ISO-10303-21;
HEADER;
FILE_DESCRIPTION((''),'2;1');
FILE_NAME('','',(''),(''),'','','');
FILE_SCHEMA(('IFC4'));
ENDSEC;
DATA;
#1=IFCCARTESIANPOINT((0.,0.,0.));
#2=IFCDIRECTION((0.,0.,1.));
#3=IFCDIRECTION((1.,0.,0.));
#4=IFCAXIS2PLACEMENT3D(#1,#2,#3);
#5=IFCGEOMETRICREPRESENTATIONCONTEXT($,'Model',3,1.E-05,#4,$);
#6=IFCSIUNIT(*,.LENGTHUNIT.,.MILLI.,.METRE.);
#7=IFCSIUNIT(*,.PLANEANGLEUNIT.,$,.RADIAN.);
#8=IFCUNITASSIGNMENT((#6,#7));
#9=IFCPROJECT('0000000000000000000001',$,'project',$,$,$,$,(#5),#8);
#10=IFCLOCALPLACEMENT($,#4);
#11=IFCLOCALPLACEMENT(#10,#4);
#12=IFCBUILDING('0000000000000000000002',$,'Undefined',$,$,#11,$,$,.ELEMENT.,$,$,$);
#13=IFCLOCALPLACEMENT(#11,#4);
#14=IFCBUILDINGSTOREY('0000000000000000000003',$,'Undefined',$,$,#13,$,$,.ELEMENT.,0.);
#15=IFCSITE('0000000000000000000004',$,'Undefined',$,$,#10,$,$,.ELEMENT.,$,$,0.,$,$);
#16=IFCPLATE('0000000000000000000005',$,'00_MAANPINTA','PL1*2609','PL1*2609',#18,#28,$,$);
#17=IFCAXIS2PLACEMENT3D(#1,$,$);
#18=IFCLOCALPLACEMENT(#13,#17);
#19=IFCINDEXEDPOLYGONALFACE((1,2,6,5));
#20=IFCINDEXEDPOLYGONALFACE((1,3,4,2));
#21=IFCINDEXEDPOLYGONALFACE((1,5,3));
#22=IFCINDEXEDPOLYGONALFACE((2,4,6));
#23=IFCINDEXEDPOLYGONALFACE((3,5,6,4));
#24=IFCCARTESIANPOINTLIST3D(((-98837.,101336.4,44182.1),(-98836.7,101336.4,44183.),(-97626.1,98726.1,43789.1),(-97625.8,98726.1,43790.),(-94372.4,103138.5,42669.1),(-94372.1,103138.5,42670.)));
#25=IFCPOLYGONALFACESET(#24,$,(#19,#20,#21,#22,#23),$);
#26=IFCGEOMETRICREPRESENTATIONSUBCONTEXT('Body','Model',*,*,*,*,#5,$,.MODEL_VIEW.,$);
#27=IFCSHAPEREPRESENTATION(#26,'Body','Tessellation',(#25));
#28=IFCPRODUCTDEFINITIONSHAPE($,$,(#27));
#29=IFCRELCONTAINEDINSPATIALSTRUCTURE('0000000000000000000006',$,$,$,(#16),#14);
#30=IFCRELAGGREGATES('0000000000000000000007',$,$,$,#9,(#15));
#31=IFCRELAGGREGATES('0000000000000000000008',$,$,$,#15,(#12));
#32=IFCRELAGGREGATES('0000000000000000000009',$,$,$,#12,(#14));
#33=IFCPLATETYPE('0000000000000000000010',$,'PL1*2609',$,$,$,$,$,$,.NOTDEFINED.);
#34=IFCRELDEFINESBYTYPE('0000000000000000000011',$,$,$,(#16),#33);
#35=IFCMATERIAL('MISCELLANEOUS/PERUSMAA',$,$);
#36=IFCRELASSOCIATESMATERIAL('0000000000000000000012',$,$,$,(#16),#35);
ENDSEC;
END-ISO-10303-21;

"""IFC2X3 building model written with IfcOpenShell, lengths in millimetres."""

from ifc_helpers import new_model, si_unit, frame, origin_with_axes, place, context, subcontext, project, spatial, polyline, outline, extrude, material, type_object, element, save


model = new_model("IFC2X3")

# Units and contexts
model_context = context("Model", 3, precision=1e-05, world=origin_with_axes())
body_context = subcontext(model_context, "Body", "Model", "MODEL_VIEW")
ifc_project = project(units=[si_unit("LENGTHUNIT", "METRE", prefix="MILLI"), si_unit("PLANEANGLEUNIT", "RADIAN")], contexts=[model_context])

# Site, building, storey
site_placement = place(None, origin_with_axes())
site = spatial("IfcSite", under=ifc_project, at=site_placement, Name="Undefined", CompositionType="ELEMENT", RefElevation=0.0)
building_placement = place(site_placement, origin_with_axes())
building = spatial("IfcBuilding", under=site, at=building_placement, Name="Undefined", CompositionType="ELEMENT")
storey_placement = place(building_placement, origin_with_axes())
storey = spatial("IfcBuildingStorey", under=building, at=storey_placement, Name="Undefined", CompositionType="ELEMENT", Elevation=0.0)

# Plate
ifc_material = material(Name="MISCELLANEOUS/PERUSMAA")
plate_type_1 = type_object("IfcPlateType", Name="PL1*2609", PredefinedType="NOTDEFINED")
plate_1_placement = place(storey_placement, frame((-98836.8, 101336.4, 44182.5), z_axis=(-0.319035, -0.005305, -0.947728), x_axis=(0.884652, 0.357087, -0.2998)))
element("IfcPlate", 1, at=plate_1_placement, inside=storey, type_object=plate_type_1, material=ifc_material, Name="00_MAANPINTA", Description="PL1*2609", ObjectType="PL1*2609", context=body_context, shape_type="SweptSolid", body=[
    extrude(outline(polyline([(0.0, 0.0), (5046.7, 0.0), (256.9, 2892.8), (0.0, 0.0)])), frame((0.0, 0.0, -0.5), z_axis=(0.0, 0.0, 1.0), x_axis=(1.0, 0.0, 0.0)), (0.0, 0.0, 1.0), 1.0),
])

save(model, "model.ifc")
